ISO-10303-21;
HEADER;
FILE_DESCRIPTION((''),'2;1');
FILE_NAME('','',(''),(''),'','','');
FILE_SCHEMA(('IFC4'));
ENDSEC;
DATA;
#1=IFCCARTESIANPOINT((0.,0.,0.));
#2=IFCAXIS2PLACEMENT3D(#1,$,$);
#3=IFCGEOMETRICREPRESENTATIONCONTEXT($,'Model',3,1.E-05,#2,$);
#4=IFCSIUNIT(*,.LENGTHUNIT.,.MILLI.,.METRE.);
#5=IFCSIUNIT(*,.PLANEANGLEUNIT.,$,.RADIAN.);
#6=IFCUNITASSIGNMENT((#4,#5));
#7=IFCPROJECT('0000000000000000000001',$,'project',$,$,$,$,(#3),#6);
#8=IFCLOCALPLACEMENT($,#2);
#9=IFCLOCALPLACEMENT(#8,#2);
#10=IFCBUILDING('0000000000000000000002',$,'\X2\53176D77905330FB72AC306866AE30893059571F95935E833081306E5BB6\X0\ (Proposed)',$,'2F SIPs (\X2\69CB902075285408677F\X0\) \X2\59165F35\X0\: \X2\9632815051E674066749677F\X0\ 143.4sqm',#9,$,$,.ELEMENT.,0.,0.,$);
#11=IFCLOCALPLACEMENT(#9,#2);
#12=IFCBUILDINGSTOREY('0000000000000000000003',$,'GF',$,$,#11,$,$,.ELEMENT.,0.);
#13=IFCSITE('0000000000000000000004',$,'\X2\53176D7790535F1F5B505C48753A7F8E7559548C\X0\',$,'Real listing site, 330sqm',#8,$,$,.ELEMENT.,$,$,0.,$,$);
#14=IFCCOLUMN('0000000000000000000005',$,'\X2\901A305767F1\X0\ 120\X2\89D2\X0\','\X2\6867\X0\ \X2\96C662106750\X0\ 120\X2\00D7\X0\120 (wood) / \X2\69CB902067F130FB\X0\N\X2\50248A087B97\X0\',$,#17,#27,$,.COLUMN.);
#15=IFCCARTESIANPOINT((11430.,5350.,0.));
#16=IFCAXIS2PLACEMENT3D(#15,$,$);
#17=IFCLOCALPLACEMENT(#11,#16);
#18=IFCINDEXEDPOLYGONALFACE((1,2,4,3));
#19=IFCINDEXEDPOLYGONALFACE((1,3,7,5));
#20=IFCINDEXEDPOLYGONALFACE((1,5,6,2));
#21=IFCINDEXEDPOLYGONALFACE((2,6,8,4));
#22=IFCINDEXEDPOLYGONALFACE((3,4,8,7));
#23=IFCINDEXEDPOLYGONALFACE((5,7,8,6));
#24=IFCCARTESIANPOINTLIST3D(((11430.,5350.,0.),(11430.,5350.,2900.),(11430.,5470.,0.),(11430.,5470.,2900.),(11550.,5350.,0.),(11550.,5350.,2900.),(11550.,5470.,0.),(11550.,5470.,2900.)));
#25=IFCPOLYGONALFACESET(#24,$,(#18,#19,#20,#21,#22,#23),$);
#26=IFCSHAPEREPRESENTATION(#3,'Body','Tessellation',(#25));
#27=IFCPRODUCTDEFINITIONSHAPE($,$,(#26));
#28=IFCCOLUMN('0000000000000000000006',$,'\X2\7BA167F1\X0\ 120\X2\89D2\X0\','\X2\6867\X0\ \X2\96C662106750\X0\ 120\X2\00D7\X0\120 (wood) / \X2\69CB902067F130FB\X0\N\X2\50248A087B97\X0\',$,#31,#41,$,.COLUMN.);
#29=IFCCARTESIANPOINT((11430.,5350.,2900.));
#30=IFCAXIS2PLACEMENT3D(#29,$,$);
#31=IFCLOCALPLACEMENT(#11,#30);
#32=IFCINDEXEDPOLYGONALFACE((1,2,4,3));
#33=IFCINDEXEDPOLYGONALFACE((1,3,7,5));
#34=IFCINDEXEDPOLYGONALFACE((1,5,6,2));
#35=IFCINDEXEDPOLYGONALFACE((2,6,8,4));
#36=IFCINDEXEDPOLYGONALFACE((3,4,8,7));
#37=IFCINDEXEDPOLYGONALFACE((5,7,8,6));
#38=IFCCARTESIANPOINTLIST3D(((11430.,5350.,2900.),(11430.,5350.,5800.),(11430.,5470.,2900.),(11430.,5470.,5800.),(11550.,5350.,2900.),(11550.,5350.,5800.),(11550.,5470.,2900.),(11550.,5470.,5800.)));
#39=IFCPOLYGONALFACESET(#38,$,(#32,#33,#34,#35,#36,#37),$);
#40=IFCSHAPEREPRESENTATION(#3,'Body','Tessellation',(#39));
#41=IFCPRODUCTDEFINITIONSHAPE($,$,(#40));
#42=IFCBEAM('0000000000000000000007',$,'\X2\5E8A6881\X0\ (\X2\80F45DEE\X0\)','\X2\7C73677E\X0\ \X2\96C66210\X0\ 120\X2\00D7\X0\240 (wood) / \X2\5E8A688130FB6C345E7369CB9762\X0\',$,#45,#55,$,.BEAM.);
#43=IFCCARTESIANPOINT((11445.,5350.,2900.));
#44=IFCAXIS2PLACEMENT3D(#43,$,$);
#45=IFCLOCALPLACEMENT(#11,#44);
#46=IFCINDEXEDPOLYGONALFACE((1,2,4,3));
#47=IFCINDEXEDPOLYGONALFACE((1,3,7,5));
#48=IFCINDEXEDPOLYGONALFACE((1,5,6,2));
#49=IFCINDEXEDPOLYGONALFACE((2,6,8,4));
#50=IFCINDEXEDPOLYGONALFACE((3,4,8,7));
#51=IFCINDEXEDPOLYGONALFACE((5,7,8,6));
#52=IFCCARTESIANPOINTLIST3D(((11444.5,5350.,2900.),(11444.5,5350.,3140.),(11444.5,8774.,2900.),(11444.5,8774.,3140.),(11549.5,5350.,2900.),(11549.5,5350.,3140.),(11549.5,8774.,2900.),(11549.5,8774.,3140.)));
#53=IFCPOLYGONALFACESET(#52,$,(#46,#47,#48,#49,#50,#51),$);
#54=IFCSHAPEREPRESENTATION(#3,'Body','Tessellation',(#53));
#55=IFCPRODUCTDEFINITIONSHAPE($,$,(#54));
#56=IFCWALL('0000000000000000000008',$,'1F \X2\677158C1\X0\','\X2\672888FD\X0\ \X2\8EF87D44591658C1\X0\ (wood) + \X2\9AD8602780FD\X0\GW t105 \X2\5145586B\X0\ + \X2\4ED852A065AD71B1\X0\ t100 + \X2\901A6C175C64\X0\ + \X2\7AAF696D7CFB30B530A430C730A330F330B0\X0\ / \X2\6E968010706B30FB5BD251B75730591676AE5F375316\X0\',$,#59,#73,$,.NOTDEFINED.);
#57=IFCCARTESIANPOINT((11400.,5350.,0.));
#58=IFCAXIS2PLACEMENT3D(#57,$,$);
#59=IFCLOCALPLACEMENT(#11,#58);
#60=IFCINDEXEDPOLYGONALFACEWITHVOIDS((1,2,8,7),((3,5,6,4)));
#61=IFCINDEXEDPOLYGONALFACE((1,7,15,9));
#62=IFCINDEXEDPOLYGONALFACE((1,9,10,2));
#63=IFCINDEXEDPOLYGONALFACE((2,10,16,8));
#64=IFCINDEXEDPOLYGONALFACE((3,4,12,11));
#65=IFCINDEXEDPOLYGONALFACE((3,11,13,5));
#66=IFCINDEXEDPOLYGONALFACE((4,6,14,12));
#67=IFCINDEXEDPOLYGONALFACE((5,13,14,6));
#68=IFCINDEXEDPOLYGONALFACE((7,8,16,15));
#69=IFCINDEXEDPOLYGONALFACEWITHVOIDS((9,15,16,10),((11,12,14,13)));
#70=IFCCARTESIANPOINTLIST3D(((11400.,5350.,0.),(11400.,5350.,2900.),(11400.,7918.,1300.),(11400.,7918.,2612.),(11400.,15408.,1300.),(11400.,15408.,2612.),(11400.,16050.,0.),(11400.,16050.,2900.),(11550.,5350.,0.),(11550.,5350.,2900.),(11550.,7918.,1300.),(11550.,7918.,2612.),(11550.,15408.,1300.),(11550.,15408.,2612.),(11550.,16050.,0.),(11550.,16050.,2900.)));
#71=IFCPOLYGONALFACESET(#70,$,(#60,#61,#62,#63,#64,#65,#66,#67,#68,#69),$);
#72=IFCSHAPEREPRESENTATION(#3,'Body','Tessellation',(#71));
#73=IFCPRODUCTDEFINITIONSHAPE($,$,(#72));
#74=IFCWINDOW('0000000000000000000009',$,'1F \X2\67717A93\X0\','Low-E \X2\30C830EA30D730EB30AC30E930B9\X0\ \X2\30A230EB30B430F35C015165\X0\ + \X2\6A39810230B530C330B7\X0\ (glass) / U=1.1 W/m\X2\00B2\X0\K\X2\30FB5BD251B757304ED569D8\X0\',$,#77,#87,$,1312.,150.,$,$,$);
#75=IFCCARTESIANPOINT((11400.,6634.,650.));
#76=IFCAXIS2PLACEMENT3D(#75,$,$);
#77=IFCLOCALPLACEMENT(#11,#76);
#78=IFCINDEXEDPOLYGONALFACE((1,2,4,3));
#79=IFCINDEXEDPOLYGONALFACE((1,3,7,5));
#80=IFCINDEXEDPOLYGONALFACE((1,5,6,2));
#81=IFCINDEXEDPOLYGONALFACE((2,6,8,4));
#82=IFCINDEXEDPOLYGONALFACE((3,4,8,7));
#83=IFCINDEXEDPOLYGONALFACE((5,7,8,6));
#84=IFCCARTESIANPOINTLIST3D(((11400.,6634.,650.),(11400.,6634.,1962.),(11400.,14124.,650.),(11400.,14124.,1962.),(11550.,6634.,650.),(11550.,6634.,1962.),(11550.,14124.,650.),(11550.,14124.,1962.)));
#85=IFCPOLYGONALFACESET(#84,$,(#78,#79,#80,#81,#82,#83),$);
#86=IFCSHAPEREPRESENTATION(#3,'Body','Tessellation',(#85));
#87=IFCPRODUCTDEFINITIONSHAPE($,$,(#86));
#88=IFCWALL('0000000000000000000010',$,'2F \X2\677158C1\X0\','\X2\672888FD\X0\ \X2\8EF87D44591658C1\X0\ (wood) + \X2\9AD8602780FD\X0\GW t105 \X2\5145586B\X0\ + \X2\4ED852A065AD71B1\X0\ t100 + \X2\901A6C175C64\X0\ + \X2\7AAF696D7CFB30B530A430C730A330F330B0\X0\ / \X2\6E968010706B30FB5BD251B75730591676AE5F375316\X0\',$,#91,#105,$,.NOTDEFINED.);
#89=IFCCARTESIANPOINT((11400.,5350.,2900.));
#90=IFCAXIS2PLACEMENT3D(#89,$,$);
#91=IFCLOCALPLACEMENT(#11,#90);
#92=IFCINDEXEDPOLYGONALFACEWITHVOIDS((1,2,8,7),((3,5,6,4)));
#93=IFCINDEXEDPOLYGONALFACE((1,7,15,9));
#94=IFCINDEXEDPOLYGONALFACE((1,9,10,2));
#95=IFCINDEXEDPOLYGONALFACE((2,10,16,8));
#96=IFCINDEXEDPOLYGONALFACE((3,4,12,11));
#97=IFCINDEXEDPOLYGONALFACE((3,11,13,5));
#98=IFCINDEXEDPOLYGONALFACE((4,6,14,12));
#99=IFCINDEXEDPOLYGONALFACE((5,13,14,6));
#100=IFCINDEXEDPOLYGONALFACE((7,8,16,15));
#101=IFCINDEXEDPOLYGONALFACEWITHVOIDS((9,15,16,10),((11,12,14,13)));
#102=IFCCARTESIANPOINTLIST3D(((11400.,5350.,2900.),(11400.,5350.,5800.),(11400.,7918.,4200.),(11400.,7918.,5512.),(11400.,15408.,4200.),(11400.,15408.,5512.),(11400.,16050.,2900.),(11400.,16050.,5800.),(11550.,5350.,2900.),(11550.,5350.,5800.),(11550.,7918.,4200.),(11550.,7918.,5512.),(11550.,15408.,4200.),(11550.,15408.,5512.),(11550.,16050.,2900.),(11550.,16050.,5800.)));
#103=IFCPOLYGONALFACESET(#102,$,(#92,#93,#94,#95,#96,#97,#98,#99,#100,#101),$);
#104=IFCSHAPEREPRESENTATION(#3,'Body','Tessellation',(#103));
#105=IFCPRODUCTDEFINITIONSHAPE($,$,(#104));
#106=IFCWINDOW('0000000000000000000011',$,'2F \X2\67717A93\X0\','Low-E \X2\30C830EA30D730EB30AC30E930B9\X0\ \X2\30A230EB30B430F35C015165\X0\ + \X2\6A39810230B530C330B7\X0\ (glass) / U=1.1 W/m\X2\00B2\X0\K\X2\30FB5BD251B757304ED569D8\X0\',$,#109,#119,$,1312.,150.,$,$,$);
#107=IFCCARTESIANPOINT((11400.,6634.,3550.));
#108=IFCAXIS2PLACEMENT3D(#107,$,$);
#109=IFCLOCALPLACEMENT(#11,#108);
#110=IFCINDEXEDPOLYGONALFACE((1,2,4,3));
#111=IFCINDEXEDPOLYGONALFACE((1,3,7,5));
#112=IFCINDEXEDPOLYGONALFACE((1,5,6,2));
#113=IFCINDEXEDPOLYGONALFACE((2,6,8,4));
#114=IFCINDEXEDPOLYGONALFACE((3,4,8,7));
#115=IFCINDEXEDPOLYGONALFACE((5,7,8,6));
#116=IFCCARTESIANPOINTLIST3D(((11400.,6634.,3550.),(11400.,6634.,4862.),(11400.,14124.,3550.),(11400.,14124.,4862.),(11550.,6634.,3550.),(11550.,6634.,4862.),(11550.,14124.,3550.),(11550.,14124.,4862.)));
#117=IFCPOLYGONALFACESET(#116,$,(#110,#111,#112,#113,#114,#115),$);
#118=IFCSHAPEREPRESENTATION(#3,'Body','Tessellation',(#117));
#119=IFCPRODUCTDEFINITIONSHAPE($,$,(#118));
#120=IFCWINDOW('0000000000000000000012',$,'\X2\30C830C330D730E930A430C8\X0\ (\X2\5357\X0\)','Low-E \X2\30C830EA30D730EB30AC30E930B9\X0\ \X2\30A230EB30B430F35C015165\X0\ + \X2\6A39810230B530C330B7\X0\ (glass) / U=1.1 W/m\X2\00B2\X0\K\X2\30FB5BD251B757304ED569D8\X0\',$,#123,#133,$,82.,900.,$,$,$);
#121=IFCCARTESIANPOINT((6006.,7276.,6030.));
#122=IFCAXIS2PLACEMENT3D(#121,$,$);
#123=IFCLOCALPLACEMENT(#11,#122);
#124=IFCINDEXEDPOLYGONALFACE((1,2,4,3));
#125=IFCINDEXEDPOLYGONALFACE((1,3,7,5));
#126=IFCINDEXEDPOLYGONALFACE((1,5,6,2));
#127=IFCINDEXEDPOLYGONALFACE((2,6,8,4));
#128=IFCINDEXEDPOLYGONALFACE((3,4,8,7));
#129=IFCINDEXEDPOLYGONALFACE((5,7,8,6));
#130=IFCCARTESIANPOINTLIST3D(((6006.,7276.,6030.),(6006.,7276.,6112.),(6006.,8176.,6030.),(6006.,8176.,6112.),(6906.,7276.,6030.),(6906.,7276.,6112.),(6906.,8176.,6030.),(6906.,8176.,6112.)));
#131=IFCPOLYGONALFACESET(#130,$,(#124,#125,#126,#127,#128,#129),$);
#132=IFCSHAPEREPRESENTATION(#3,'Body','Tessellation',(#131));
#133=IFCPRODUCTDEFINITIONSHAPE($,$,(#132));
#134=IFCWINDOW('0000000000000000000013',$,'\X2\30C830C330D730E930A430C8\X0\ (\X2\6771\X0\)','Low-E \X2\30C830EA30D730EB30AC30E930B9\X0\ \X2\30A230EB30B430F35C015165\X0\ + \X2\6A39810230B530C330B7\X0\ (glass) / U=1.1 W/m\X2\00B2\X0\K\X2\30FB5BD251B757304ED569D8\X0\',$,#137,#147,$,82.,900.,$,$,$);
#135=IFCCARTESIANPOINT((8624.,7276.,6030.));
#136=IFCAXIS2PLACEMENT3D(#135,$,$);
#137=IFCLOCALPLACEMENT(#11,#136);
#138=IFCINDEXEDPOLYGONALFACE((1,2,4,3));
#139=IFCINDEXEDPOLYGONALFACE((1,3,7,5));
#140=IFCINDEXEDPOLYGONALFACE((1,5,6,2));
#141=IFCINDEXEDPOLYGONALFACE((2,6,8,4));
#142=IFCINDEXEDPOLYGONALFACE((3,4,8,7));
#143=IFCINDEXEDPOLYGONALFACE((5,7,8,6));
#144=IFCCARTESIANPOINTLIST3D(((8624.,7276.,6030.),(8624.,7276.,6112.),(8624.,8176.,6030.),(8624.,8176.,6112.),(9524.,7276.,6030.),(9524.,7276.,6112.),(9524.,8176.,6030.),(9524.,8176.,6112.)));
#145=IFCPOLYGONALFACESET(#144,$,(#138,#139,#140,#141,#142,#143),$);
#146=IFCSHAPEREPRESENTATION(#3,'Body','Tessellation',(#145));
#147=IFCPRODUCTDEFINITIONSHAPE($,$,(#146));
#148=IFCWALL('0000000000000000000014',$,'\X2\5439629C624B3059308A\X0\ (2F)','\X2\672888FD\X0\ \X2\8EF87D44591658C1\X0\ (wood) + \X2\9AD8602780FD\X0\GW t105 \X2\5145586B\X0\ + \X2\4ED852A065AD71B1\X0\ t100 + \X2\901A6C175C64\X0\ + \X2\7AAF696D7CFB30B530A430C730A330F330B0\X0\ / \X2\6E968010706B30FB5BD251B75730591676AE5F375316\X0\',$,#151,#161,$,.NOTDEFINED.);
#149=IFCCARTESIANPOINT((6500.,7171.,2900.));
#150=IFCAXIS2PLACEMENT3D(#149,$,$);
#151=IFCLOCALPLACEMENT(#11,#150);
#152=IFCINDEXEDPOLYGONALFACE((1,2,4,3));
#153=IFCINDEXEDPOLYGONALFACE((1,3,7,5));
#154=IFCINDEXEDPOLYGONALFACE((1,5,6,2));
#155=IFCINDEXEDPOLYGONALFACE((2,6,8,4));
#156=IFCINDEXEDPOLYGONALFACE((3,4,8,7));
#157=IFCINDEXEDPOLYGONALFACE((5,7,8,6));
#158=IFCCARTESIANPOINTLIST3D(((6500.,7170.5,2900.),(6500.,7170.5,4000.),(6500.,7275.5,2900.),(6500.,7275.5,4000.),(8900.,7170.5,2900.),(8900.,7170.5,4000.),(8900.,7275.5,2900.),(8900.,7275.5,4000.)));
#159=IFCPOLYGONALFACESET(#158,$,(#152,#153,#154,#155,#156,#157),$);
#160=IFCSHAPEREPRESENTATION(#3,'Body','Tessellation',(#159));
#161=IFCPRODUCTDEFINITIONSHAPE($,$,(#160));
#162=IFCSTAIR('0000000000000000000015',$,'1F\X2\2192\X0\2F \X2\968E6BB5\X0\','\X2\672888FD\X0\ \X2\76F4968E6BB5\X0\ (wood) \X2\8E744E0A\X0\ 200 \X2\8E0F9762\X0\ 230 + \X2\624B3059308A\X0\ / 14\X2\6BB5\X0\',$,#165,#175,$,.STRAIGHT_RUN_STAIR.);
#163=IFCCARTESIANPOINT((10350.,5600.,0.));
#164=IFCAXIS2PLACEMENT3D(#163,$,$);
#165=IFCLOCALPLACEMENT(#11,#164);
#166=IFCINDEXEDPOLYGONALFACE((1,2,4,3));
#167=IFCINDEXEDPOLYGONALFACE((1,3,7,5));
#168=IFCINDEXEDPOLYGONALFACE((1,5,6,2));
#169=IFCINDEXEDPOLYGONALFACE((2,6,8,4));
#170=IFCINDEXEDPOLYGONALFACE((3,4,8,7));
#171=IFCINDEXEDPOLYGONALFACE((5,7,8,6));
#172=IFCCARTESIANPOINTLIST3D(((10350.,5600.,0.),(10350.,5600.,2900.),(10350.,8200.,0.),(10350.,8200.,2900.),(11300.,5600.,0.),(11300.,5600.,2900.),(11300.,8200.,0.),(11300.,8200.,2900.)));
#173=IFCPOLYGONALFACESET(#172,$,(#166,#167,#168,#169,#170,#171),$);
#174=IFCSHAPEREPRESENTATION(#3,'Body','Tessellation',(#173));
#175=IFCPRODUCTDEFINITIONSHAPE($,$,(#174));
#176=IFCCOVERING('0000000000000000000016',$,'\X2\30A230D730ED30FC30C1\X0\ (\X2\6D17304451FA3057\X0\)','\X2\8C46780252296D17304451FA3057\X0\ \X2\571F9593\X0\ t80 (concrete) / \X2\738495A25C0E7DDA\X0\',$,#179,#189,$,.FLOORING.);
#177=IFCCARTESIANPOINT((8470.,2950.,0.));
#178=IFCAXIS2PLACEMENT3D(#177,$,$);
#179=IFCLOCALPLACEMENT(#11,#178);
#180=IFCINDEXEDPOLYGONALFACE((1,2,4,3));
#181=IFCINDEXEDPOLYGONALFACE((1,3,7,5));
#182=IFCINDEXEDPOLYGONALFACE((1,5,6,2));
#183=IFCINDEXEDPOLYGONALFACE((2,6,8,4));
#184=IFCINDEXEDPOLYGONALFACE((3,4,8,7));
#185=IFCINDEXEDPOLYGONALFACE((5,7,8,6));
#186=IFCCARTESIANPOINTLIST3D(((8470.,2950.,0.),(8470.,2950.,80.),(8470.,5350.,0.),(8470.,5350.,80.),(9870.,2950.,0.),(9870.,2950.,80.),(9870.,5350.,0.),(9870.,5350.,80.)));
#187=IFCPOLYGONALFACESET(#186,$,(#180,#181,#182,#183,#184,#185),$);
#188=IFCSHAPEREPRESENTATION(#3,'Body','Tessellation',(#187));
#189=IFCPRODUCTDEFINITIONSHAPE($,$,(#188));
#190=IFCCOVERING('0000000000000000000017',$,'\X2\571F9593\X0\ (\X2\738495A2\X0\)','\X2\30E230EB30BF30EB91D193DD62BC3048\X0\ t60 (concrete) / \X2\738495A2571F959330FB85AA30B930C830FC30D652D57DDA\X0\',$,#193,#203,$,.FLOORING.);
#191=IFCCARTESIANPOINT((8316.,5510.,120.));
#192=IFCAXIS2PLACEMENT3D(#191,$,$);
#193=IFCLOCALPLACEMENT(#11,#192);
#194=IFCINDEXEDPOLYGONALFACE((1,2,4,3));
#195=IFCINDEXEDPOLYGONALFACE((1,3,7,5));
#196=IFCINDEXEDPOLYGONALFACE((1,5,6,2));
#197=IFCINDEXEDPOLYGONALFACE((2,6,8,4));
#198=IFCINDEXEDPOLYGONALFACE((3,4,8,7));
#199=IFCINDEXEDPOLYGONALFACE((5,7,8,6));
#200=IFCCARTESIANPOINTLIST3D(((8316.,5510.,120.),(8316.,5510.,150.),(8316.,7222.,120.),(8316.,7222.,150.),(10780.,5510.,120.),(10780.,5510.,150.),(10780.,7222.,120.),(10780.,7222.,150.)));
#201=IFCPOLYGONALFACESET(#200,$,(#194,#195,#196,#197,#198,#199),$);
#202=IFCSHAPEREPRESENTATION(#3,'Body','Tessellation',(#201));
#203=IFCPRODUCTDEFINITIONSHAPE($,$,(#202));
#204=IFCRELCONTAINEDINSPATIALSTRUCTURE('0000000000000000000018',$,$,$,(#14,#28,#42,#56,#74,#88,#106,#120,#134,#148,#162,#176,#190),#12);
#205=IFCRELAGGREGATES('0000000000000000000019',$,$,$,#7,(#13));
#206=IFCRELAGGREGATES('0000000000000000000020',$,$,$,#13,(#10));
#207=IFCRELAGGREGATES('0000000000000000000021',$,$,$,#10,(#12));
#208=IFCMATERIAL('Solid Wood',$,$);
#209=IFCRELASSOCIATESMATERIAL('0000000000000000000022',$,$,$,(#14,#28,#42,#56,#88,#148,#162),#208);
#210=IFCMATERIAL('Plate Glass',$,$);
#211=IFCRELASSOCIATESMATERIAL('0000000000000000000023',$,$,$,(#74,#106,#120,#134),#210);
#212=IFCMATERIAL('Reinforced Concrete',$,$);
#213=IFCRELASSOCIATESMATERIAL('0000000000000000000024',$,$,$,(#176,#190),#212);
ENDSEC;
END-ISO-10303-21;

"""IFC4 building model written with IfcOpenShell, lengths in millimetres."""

from ifc_helpers import new_model, si_unit, frame, frame_2d, origin, place, context, project, spatial, rectangle, extrude, material, element, fill, save


model = new_model("IFC4")

# Units and contexts
model_context = context("Model", 3, precision=1e-05, world=origin())
ifc_project = project(units=[si_unit("LENGTHUNIT", "METRE", prefix="MILLI"), si_unit("PLANEANGLEUNIT", "RADIAN")], contexts=[model_context])

# Site, building, storey
site_placement = place(None, origin())
site = spatial("IfcSite", under=ifc_project, at=site_placement, Name="北海道弟子屈町美留和", ObjectType="Real listing site, 330sqm", CompositionType="ELEMENT", RefElevation=0.0)
building_placement = place(site_placement, origin())
building = spatial("IfcBuilding", under=site, at=building_placement, Name="北海道・犬と暮らす土間広めの家 (Proposed)", ObjectType="2F SIPs (構造用合板) 外張: 防腐処理杉板 143.4sqm", CompositionType="ELEMENT", ElevationOfRefHeight=0.0, ElevationOfTerrain=0.0)
storey_placement = place(building_placement, origin())
storey = spatial("IfcBuildingStorey", under=building, at=storey_placement, Name="GF", CompositionType="ELEMENT", Elevation=0.0)

# Columns
ifc_material_1 = material(Name="Solid Wood")
column_1_placement = place(storey_placement, frame((11430.0, 5350.0, 0.0)))
element("IfcColumn", 1, at=column_1_placement, inside=storey, material=ifc_material_1, Name="通し柱 120角", Description="桧 集成材 120×120 (wood) / 構造柱・N値計算", PredefinedType="COLUMN", context=model_context, shape_type="SweptSolid", body=[
    extrude(rectangle(XDim=120.0, YDim=120.0, at=frame_2d((60.0, 60.0))), frame((11430.0, 5350.0, 0.0)), (0.0, 0.0, 1.0), 2900.0),
])
column_2_placement = place(storey_placement, frame((11430.0, 5350.0, 2900.0)))
element("IfcColumn", 2, at=column_2_placement, inside=storey, material=ifc_material_1, Name="管柱 120角", Description="桧 集成材 120×120 (wood) / 構造柱・N値計算", PredefinedType="COLUMN", context=model_context, shape_type="SweptSolid", body=[
    extrude(rectangle(XDim=120.0, YDim=120.0, at=frame_2d((60.0, 60.0))), frame((11430.0, 5350.0, 2900.0)), (0.0, 0.0, 1.0), 2900.0),
])

# Beam
beam_1_placement = place(storey_placement, frame((11445.0, 5350.0, 2900.0)))
element("IfcBeam", 3, at=beam_1_placement, inside=storey, material=ifc_material_1, Name="床梁 (胴差)", Description="米松 集成 120×240 (wood) / 床梁・水平構面", PredefinedType="BEAM", context=model_context, shape_type="SweptSolid", body=[
    extrude(rectangle(XDim=105.0, YDim=3424.0, at=frame_2d((52.0, 1712.0))), frame((11445.0, 5350.0, 2900.0)), (0.0, 0.0, 1.0), 240.0),
])

# Wall, opening, window
wall_1_placement = place(storey_placement, frame((11400.0, 5350.0, 0.0)))
wall_1 = element("IfcWall", 4, at=wall_1_placement, inside=storey, material=ifc_material_1, Name="1F 東壁", Description="木製 軸組外壁 (wood) + 高性能GW t105 充填 + 付加断熱 t100 + 通気層 + 窯業系サイディング / 準耐火・寒冷地外皮強化", PredefinedType="NOTDEFINED", context=model_context, shape_type="SweptSolid", body=[
    extrude(rectangle(XDim=150.0, YDim=10700.0, at=frame_2d((75.0, 5350.0))), frame((11400.0, 5350.0, 0.0)), (0.0, 0.0, 1.0), 2900.0),
])
opening_1_placement = place(storey_placement, frame((11400.0, 6634.0, 650.0)))
opening_1 = element("IfcOpeningElement", 5, at=opening_1_placement, cuts=wall_1, PredefinedType="NOTDEFINED", context=model_context, shape_type="SweptSolid", body=[
    extrude(rectangle(XDim=150.0, YDim=7490.0, at=frame_2d((75.0, 3745.0))), frame((11400.0, 6634.0, 650.0)), (0.0, 0.0, 1.0), 1312.0),
])
ifc_material_2 = material(Name="Plate Glass")
window_1_placement = place(storey_placement, frame((11400.0, 6634.0, 650.0)))
window_1 = element("IfcWindow", 6, at=window_1_placement, inside=storey, material=ifc_material_2, Name="1F 東窓", Description="Low-E トリプルガラス アルゴン封入 + 樹脂サッシ (glass) / U=1.1 W/m²K・寒冷地仕様", OverallHeight=1312.0, OverallWidth=150.0, context=model_context, shape_type="SweptSolid", body=[
    extrude(rectangle(XDim=150.0, YDim=7490.0, at=frame_2d((75.0, 3745.0))), frame((11400.0, 6634.0, 650.0)), (0.0, 0.0, 1.0), 1312.0),
])
fill(opening_1, window_1)

# Wall, opening, window
wall_2_placement = place(storey_placement, frame((11400.0, 5350.0, 2900.0)))
wall_2 = element("IfcWall", 7, at=wall_2_placement, inside=storey, material=ifc_material_1, Name="2F 東壁", Description="木製 軸組外壁 (wood) + 高性能GW t105 充填 + 付加断熱 t100 + 通気層 + 窯業系サイディング / 準耐火・寒冷地外皮強化", PredefinedType="NOTDEFINED", context=model_context, shape_type="SweptSolid", body=[
    extrude(rectangle(XDim=150.0, YDim=10700.0, at=frame_2d((75.0, 5350.0))), frame((11400.0, 5350.0, 2900.0)), (0.0, 0.0, 1.0), 2900.0),
])
opening_2_placement = place(storey_placement, frame((11400.0, 6634.0, 3550.0)))
opening_2 = element("IfcOpeningElement", 8, at=opening_2_placement, cuts=wall_2, PredefinedType="NOTDEFINED", context=model_context, shape_type="SweptSolid", body=[
    extrude(rectangle(XDim=150.0, YDim=7490.0, at=frame_2d((75.0, 3745.0))), frame((11400.0, 6634.0, 3550.0)), (0.0, 0.0, 1.0), 1312.0),
])
window_2_placement = place(storey_placement, frame((11400.0, 6634.0, 3550.0)))
window_2 = element("IfcWindow", 9, at=window_2_placement, inside=storey, material=ifc_material_2, Name="2F 東窓", Description="Low-E トリプルガラス アルゴン封入 + 樹脂サッシ (glass) / U=1.1 W/m²K・寒冷地仕様", OverallHeight=1312.0, OverallWidth=150.0, context=model_context, shape_type="SweptSolid", body=[
    extrude(rectangle(XDim=150.0, YDim=7490.0, at=frame_2d((75.0, 3745.0))), frame((11400.0, 6634.0, 3550.0)), (0.0, 0.0, 1.0), 1312.0),
])
fill(opening_2, window_2)

# Windows
window_3_placement = place(storey_placement, frame((6006.0, 7276.0, 6030.0)))
element("IfcWindow", 10, at=window_3_placement, inside=storey, material=ifc_material_2, Name="トップライト (南)", Description="Low-E トリプルガラス アルゴン封入 + 樹脂サッシ (glass) / U=1.1 W/m²K・寒冷地仕様", OverallHeight=82.0, OverallWidth=900.0, context=model_context, shape_type="SweptSolid", body=[
    extrude(rectangle(XDim=900.0, YDim=900.0, at=frame_2d((450.0, 450.0))), frame((6006.0, 7276.0, 6030.0)), (0.0, 0.0, 1.0), 82.0),
])
window_4_placement = place(storey_placement, frame((8624.0, 7276.0, 6030.0)))
element("IfcWindow", 11, at=window_4_placement, inside=storey, material=ifc_material_2, Name="トップライト (東)", Description="Low-E トリプルガラス アルゴン封入 + 樹脂サッシ (glass) / U=1.1 W/m²K・寒冷地仕様", OverallHeight=82.0, OverallWidth=900.0, context=model_context, shape_type="SweptSolid", body=[
    extrude(rectangle(XDim=900.0, YDim=900.0, at=frame_2d((450.0, 450.0))), frame((8624.0, 7276.0, 6030.0)), (0.0, 0.0, 1.0), 82.0),
])

# Wall
wall_3_placement = place(storey_placement, frame((6500.0, 7171.0, 2900.0)))
element("IfcWall", 12, at=wall_3_placement, inside=storey, material=ifc_material_1, Name="吹抜手すり (2F)", Description="木製 軸組外壁 (wood) + 高性能GW t105 充填 + 付加断熱 t100 + 通気層 + 窯業系サイディング / 準耐火・寒冷地外皮強化", PredefinedType="NOTDEFINED", context=model_context, shape_type="SweptSolid", body=[
    extrude(rectangle(XDim=2400.0, YDim=105.0, at=frame_2d((1200.0, 52.0))), frame((6500.0, 7171.0, 2900.0)), (0.0, 0.0, 1.0), 1100.0),
])

# Stair
stair_placement = place(storey_placement, frame((10350.0, 5600.0, 0.0)))
element("IfcStair", 13, at=stair_placement, inside=storey, material=ifc_material_1, Name="1F→2F 階段", Description="木製 直階段 (wood) 蹴上 200 踏面 230 + 手すり / 14段", PredefinedType="STRAIGHT_RUN_STAIR", context=model_context, shape_type="SweptSolid", body=[
    extrude(rectangle(XDim=950.0, YDim=2600.0, at=frame_2d((475.0, 1300.0))), frame((10350.0, 5600.0, 0.0)), (0.0, 0.0, 1.0), 2900.0),
])

# Coverings
ifc_material_3 = material(Name="Reinforced Concrete")
covering_1_placement = place(storey_placement, frame((8470.0, 2950.0, 0.0)))
element("IfcCovering", 14, at=covering_1_placement, inside=storey, material=ifc_material_3, Name="アプローチ (洗い出し)", Description="豆砂利洗い出し 土間 t80 (concrete) / 玄関導線", PredefinedType="FLOORING", context=model_context, shape_type="SweptSolid", body=[
    extrude(rectangle(XDim=1400.0, YDim=2400.0, at=frame_2d((700.0, 1200.0))), frame((8470.0, 2950.0, 0.0)), (0.0, 0.0, 1.0), 80.0),
])
covering_2_placement = place(storey_placement, frame((8316.0, 5510.0, 120.0)))
element("IfcCovering", 15, at=covering_2_placement, inside=storey, material=ifc_material_3, Name="土間 (玄関)", Description="モルタル金鏝押え t60 (concrete) / 玄関土間・薪ストーブ動線", PredefinedType="FLOORING", context=model_context, shape_type="SweptSolid", body=[
    extrude(rectangle(XDim=2464.0, YDim=1712.0, at=frame_2d((1232.0, 856.0))), frame((8316.0, 5510.0, 120.0)), (0.0, 0.0, 1.0), 30.0),
])

save(model, "model.ifc")
